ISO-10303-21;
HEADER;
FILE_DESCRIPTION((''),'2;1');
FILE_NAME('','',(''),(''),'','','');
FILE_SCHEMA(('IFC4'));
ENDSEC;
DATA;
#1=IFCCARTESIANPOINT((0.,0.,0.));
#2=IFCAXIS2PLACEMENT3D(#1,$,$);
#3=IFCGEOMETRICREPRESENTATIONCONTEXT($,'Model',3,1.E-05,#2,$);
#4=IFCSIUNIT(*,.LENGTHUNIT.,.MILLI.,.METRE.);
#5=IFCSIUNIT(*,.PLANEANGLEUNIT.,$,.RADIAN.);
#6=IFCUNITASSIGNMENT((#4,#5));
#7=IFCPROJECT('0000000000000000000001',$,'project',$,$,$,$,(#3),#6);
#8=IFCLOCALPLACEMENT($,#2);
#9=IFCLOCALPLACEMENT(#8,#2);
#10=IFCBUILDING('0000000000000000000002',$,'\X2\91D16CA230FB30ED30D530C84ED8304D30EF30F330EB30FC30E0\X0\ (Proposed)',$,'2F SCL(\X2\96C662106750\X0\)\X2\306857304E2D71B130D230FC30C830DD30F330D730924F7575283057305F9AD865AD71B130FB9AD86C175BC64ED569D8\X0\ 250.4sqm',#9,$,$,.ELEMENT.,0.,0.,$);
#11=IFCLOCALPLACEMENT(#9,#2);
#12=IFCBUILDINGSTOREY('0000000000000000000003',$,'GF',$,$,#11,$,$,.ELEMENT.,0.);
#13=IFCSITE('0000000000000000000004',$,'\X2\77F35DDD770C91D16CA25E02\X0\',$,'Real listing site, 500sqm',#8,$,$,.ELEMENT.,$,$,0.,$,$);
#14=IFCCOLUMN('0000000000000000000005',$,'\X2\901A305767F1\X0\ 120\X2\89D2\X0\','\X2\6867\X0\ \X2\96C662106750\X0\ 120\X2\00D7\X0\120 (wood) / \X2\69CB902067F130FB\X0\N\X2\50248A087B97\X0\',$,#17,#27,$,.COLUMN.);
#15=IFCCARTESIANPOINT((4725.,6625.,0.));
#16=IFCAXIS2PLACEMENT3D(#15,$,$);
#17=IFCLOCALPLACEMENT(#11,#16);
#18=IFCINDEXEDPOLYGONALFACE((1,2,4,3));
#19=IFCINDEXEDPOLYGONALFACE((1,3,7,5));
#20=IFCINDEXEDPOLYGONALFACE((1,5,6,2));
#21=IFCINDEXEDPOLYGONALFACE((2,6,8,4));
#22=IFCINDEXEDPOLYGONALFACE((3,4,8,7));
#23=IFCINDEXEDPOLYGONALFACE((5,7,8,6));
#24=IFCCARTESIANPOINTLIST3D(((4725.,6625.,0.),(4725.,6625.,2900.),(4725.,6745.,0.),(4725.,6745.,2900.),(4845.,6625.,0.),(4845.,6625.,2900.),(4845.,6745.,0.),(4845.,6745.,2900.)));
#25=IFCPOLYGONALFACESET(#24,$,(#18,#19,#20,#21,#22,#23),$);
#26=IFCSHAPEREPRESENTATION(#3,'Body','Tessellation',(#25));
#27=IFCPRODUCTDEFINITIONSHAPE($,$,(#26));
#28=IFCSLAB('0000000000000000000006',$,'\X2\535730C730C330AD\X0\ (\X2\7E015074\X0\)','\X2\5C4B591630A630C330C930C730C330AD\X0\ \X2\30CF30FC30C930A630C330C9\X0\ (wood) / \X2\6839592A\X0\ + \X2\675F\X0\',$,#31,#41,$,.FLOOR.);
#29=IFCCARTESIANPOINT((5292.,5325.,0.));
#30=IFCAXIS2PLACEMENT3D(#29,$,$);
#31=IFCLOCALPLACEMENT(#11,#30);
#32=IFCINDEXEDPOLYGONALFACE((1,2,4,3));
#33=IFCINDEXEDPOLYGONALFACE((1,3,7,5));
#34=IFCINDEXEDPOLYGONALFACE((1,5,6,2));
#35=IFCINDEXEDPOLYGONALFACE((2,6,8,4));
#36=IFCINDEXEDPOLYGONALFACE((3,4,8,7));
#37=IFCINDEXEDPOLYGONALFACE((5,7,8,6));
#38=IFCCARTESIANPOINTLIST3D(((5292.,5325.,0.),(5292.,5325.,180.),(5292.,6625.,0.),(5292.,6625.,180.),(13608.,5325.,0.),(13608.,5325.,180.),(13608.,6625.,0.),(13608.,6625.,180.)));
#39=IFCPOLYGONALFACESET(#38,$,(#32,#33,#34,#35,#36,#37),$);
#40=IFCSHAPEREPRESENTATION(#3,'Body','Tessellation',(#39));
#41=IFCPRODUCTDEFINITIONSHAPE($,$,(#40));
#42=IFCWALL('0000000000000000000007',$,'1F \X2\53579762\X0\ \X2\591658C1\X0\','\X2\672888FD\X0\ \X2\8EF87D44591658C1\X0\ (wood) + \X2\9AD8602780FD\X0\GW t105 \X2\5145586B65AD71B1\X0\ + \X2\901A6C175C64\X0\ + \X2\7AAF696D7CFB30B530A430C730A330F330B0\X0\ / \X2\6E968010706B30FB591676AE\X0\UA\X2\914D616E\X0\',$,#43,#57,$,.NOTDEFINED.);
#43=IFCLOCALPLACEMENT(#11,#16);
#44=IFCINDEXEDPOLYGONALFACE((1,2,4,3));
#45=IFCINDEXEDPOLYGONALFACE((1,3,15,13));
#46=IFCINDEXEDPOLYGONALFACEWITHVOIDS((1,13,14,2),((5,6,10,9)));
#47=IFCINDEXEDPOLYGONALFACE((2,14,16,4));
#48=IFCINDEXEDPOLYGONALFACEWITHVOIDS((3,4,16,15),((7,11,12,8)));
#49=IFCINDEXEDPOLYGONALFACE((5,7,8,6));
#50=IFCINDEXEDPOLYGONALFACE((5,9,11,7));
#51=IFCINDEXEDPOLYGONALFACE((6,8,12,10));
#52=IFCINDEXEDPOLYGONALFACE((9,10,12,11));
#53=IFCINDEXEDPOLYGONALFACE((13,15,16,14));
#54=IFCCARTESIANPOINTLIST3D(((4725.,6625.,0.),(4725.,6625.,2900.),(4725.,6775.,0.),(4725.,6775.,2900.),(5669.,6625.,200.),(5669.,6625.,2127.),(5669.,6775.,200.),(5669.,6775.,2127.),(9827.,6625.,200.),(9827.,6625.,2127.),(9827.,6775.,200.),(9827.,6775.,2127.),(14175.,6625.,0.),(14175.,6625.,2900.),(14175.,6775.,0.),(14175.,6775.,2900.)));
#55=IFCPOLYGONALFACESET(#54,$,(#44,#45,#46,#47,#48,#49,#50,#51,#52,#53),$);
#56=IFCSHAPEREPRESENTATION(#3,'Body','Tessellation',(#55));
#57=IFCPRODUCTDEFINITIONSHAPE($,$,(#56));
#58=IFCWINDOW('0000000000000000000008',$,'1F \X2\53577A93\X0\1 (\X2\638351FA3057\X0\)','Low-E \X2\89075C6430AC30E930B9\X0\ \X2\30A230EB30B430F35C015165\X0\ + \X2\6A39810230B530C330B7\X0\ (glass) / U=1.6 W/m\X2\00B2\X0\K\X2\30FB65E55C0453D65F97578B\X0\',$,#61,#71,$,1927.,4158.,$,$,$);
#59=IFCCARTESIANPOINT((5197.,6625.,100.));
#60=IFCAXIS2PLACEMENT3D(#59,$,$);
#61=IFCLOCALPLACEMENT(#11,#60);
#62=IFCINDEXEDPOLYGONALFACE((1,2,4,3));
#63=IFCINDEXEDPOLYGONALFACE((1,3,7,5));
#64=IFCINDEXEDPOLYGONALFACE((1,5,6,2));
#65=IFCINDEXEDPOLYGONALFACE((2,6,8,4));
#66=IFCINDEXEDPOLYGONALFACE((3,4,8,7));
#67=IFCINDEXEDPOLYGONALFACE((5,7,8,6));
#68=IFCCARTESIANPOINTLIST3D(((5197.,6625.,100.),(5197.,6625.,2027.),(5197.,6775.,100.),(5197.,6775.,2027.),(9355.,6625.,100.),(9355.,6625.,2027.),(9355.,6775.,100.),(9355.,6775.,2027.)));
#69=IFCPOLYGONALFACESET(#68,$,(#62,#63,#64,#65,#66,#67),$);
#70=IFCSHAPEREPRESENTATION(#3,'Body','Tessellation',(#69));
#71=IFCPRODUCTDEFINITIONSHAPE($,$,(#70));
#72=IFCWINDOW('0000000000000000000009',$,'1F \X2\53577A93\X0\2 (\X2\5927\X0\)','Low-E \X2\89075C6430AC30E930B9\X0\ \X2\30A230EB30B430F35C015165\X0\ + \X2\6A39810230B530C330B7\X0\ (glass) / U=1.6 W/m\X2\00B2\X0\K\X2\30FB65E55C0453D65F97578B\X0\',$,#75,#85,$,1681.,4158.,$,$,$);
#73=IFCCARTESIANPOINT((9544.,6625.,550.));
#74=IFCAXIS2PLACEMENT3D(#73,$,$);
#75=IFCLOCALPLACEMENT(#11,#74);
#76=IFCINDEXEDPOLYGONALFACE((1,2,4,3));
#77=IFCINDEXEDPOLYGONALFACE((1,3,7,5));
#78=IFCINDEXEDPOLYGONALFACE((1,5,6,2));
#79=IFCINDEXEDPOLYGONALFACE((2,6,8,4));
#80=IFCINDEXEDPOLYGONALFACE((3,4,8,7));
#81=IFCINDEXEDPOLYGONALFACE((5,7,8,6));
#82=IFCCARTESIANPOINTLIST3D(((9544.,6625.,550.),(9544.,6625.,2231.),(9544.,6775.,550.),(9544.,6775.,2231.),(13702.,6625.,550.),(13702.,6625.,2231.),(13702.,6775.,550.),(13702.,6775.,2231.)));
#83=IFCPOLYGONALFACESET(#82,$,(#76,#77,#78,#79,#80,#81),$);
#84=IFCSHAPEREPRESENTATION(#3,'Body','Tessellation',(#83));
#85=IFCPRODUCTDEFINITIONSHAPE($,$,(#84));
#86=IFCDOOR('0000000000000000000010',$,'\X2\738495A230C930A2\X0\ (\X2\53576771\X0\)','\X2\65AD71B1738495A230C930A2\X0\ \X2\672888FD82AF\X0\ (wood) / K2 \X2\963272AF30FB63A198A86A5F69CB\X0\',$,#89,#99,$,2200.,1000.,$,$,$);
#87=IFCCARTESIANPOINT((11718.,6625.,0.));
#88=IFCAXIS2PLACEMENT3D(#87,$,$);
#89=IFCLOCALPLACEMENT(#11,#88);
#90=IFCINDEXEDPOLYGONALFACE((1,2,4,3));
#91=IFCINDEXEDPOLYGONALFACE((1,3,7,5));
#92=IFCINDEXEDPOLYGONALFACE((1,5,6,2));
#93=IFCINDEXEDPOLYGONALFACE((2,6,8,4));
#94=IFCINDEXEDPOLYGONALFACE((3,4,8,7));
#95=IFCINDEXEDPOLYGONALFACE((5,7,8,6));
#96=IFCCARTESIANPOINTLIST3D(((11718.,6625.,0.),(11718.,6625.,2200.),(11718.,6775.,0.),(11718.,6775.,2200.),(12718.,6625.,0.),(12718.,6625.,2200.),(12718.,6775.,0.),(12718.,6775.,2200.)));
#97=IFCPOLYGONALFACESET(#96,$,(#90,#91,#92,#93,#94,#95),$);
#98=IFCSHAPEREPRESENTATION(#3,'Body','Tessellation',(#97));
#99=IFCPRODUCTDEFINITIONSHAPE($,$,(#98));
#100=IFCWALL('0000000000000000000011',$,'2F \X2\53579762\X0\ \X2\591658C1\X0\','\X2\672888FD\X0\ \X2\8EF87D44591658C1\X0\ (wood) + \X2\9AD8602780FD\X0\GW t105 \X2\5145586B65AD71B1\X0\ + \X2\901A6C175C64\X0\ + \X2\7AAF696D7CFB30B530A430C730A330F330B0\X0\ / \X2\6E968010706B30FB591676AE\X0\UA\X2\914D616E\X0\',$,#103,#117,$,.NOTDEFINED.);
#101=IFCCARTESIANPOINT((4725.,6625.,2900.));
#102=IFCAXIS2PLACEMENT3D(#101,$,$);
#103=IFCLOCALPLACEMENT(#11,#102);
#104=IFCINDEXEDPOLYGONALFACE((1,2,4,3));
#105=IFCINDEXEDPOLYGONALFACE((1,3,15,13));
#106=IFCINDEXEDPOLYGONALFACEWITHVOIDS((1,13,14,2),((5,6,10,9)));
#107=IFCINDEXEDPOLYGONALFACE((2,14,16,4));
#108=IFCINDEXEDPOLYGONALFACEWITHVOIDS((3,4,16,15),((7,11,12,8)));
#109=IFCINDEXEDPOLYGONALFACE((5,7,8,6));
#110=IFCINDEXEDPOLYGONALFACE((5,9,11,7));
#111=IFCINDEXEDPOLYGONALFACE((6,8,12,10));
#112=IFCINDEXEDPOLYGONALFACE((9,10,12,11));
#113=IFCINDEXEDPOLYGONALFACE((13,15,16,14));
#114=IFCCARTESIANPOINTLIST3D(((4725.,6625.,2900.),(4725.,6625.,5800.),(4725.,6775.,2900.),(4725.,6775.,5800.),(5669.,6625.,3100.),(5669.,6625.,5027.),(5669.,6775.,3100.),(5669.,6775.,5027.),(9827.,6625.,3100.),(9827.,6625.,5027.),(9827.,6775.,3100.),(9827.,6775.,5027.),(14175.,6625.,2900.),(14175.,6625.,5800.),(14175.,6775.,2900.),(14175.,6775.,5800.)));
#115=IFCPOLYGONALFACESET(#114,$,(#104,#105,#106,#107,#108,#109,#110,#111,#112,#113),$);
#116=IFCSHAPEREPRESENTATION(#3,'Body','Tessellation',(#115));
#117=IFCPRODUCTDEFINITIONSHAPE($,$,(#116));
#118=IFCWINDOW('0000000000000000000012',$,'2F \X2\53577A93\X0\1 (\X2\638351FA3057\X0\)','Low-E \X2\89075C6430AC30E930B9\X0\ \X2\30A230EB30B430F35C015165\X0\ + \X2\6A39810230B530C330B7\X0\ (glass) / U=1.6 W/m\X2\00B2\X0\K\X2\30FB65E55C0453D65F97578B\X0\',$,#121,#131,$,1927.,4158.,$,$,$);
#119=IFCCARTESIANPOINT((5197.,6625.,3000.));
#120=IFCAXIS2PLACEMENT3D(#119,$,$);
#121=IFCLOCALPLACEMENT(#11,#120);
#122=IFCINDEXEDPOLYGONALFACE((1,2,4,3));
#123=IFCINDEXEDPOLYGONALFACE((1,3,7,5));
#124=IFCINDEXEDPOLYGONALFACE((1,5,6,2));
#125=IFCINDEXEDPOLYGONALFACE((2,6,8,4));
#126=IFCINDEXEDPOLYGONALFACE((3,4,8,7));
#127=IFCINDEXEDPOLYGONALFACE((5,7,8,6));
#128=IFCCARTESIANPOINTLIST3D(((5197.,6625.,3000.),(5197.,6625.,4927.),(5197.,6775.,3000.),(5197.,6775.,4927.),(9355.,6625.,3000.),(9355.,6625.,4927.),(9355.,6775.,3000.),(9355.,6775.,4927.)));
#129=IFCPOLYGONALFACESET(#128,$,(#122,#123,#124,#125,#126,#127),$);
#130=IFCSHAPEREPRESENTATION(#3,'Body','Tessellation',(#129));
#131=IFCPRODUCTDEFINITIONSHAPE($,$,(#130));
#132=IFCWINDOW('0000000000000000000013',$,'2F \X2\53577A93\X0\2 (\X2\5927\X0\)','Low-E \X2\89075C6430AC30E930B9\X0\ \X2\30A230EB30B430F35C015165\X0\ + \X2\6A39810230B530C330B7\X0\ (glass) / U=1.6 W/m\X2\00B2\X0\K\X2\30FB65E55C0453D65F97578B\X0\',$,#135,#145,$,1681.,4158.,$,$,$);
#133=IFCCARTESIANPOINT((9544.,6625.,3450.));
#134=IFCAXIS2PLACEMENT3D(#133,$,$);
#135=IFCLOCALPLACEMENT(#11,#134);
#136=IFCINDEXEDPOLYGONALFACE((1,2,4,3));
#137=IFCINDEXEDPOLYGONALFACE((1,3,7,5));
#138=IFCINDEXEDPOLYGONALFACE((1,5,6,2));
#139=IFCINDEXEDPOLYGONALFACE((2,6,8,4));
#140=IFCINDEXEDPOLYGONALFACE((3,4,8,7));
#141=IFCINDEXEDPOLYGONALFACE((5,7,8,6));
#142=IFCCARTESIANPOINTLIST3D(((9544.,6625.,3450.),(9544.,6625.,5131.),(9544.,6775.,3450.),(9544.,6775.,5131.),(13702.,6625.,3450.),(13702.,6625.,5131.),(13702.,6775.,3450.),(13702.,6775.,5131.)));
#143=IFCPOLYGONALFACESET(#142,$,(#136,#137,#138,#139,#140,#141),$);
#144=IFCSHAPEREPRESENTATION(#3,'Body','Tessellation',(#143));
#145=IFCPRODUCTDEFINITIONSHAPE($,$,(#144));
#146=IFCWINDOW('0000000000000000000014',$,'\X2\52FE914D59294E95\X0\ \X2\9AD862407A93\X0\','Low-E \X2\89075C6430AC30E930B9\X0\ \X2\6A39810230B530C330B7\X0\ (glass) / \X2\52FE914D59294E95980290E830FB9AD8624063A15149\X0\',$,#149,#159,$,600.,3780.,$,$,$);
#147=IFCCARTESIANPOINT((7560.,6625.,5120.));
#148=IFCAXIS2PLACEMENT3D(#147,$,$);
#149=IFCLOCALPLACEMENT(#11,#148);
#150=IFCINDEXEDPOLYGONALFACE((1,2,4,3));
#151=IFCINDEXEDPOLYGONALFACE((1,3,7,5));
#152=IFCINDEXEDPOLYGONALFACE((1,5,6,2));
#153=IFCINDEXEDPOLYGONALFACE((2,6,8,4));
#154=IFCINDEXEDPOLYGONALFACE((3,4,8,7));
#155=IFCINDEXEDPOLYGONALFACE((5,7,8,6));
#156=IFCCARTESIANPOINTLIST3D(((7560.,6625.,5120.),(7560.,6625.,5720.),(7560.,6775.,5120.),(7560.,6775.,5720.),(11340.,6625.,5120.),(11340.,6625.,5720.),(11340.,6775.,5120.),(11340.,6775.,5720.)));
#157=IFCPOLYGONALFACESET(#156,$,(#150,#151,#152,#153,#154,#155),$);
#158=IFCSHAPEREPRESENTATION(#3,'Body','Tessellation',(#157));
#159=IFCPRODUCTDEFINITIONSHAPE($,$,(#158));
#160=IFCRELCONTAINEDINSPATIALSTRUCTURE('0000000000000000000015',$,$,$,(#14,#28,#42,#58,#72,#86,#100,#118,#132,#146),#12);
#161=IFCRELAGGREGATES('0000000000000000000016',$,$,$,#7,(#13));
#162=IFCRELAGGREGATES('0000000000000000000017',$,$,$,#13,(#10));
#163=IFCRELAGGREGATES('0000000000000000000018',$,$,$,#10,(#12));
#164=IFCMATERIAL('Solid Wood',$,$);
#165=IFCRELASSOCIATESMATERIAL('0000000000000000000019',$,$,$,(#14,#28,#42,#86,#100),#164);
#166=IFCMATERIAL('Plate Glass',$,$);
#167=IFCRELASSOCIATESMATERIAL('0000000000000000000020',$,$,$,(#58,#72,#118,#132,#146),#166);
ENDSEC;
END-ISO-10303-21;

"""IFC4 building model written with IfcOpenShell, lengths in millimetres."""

from ifc_helpers import new_model, si_unit, frame, frame_2d, origin, place, context, project, spatial, rectangle, extrude, material, element, fill, save


model = new_model("IFC4")

# Units and contexts
model_context = context("Model", 3, precision=1e-05, world=origin())
ifc_project = project(units=[si_unit("LENGTHUNIT", "METRE", prefix="MILLI"), si_unit("PLANEANGLEUNIT", "RADIAN")], contexts=[model_context])

# Site, building, storey
site_placement = place(None, origin())
site = spatial("IfcSite", under=ifc_project, at=site_placement, Name="石川県金沢市", ObjectType="Real listing site, 500sqm", CompositionType="ELEMENT", RefElevation=0.0)
building_placement = place(site_placement, origin())
building = spatial("IfcBuilding", under=site, at=building_placement, Name="金沢・ロフト付きワンルーム (Proposed)", ObjectType="2F SCL(集成材)と地中熱ヒートポンプを併用した高断熱・高気密仕様 250.4sqm", CompositionType="ELEMENT", ElevationOfRefHeight=0.0, ElevationOfTerrain=0.0)
storey_placement = place(building_placement, origin())
storey = spatial("IfcBuildingStorey", under=building, at=storey_placement, Name="GF", CompositionType="ELEMENT", Elevation=0.0)

# Column
ifc_material_1 = material(Name="Solid Wood")
column_placement = place(storey_placement, frame((4725.0, 6625.0, 0.0)))
element("IfcColumn", 1, at=column_placement, inside=storey, material=ifc_material_1, Name="通し柱 120角", Description="桧 集成材 120×120 (wood) / 構造柱・N値計算", PredefinedType="COLUMN", context=model_context, shape_type="SweptSolid", body=[
    extrude(rectangle(XDim=120.0, YDim=120.0, at=frame_2d((60.0, 60.0))), frame((4725.0, 6625.0, 0.0)), (0.0, 0.0, 1.0), 2900.0),
])

# Slab
slab_1_placement = place(storey_placement, frame((5292.0, 5325.0, 0.0)))
element("IfcSlab", 2, at=slab_1_placement, inside=storey, material=ifc_material_1, Name="南デッキ (縁側)", Description="屋外ウッドデッキ ハードウッド (wood) / 根太 + 束", PredefinedType="FLOOR", context=model_context, shape_type="SweptSolid", body=[
    extrude(rectangle(XDim=8316.0, YDim=1300.0, at=frame_2d((4158.0, 650.0))), frame((5292.0, 5325.0, 0.0)), (0.0, 0.0, 1.0), 180.0),
])

# Wall, openings, windows, door
wall_1_placement = place(storey_placement, frame((4725.0, 6625.0, 0.0)))
wall_1 = element("IfcWall", 3, at=wall_1_placement, inside=storey, material=ifc_material_1, Name="1F 南面 外壁", Description="木製 軸組外壁 (wood) + 高性能GW t105 充填断熱 + 通気層 + 窯業系サイディング / 準耐火・外皮UA配慮", PredefinedType="NOTDEFINED", context=model_context, shape_type="SweptSolid", body=[
    extrude(rectangle(XDim=9450.0, YDim=150.0, at=frame_2d((4725.0, 75.0))), frame((4725.0, 6625.0, 0.0)), (0.0, 0.0, 1.0), 2900.0),
])
opening_1_placement = place(storey_placement, frame((5197.0, 6625.0, 100.0)))
opening_1 = element("IfcOpeningElement", 4, at=opening_1_placement, cuts=wall_1, PredefinedType="NOTDEFINED", context=model_context, shape_type="SweptSolid", body=[
    extrude(rectangle(XDim=4158.0, YDim=150.0, at=frame_2d((2079.0, 75.0))), frame((5197.0, 6625.0, 100.0)), (0.0, 0.0, 1.0), 1927.0),
])
opening_2_placement = place(storey_placement, frame((9544.0, 6625.0, 550.0)))
opening_2 = element("IfcOpeningElement", 5, at=opening_2_placement, cuts=wall_1, PredefinedType="NOTDEFINED", context=model_context, shape_type="SweptSolid", body=[
    extrude(rectangle(XDim=4158.0, YDim=150.0, at=frame_2d((2079.0, 75.0))), frame((9544.0, 6625.0, 550.0)), (0.0, 0.0, 1.0), 1681.0),
])
opening_3_placement = place(storey_placement, frame((11718.0, 6625.0, 0.0)))
opening_3 = element("IfcOpeningElement", 6, at=opening_3_placement, cuts=wall_1, PredefinedType="NOTDEFINED", context=model_context, shape_type="SweptSolid", body=[
    extrude(rectangle(XDim=1000.0, YDim=150.0, at=frame_2d((500.0, 75.0))), frame((11718.0, 6625.0, 0.0)), (0.0, 0.0, 1.0), 2200.0),
])
ifc_material_2 = material(Name="Plate Glass")
window_1_placement = place(storey_placement, frame((5197.0, 6625.0, 100.0)))
window_1 = element("IfcWindow", 7, at=window_1_placement, inside=storey, material=ifc_material_2, Name="1F 南窓1 (掃出し)", Description="Low-E 複層ガラス アルゴン封入 + 樹脂サッシ (glass) / U=1.6 W/m²K・日射取得型", OverallHeight=1927.0, OverallWidth=4158.0, context=model_context, shape_type="SweptSolid", body=[
    extrude(rectangle(XDim=4158.0, YDim=150.0, at=frame_2d((2079.0, 75.0))), frame((5197.0, 6625.0, 100.0)), (0.0, 0.0, 1.0), 1927.0),
])
fill(opening_1, window_1)
window_2_placement = place(storey_placement, frame((9544.0, 6625.0, 550.0)))
window_2 = element("IfcWindow", 8, at=window_2_placement, inside=storey, material=ifc_material_2, Name="1F 南窓2 (大)", Description="Low-E 複層ガラス アルゴン封入 + 樹脂サッシ (glass) / U=1.6 W/m²K・日射取得型", OverallHeight=1681.0, OverallWidth=4158.0, context=model_context, shape_type="SweptSolid", body=[
    extrude(rectangle(XDim=4158.0, YDim=150.0, at=frame_2d((2079.0, 75.0))), frame((9544.0, 6625.0, 550.0)), (0.0, 0.0, 1.0), 1681.0),
])
fill(opening_2, window_2)
door_placement = place(storey_placement, frame((11718.0, 6625.0, 0.0)))
door = element("IfcDoor", 9, at=door_placement, inside=storey, material=ifc_material_1, Name="玄関ドア (南東)", Description="断熱玄関ドア 木製芯 (wood) / K2 防犯・採風機構", OverallHeight=2200.0, OverallWidth=1000.0, context=model_context, shape_type="SweptSolid", body=[
    extrude(rectangle(XDim=1000.0, YDim=150.0, at=frame_2d((500.0, 75.0))), frame((11718.0, 6625.0, 0.0)), (0.0, 0.0, 1.0), 2200.0),
])
fill(opening_3, door)

# Wall, openings, windows
wall_2_placement = place(storey_placement, frame((4725.0, 6625.0, 2900.0)))
wall_2 = element("IfcWall", 10, at=wall_2_placement, inside=storey, material=ifc_material_1, Name="2F 南面 外壁", Description="木製 軸組外壁 (wood) + 高性能GW t105 充填断熱 + 通気層 + 窯業系サイディング / 準耐火・外皮UA配慮", PredefinedType="NOTDEFINED", context=model_context, shape_type="SweptSolid", body=[
    extrude(rectangle(XDim=9450.0, YDim=150.0, at=frame_2d((4725.0, 75.0))), frame((4725.0, 6625.0, 2900.0)), (0.0, 0.0, 1.0), 2900.0),
])
opening_4_placement = place(storey_placement, frame((5197.0, 6625.0, 3000.0)))
opening_4 = element("IfcOpeningElement", 11, at=opening_4_placement, cuts=wall_2, PredefinedType="NOTDEFINED", context=model_context, shape_type="SweptSolid", body=[
    extrude(rectangle(XDim=4158.0, YDim=150.0, at=frame_2d((2079.0, 75.0))), frame((5197.0, 6625.0, 3000.0)), (0.0, 0.0, 1.0), 1927.0),
])
opening_5_placement = place(storey_placement, frame((9544.0, 6625.0, 3450.0)))
opening_5 = element("IfcOpeningElement", 12, at=opening_5_placement, cuts=wall_2, PredefinedType="NOTDEFINED", context=model_context, shape_type="SweptSolid", body=[
    extrude(rectangle(XDim=4158.0, YDim=150.0, at=frame_2d((2079.0, 75.0))), frame((9544.0, 6625.0, 3450.0)), (0.0, 0.0, 1.0), 1681.0),
])
opening_6_placement = place(storey_placement, frame((7560.0, 6625.0, 5120.0)))
opening_6 = element("IfcOpeningElement", 13, at=opening_6_placement, cuts=wall_2, PredefinedType="NOTDEFINED", context=model_context, shape_type="SweptSolid", body=[
    extrude(rectangle(XDim=3780.0, YDim=150.0, at=frame_2d((1890.0, 75.0))), frame((7560.0, 6625.0, 5120.0)), (0.0, 0.0, 1.0), 600.0),
])
window_3_placement = place(storey_placement, frame((5197.0, 6625.0, 3000.0)))
window_3 = element("IfcWindow", 14, at=window_3_placement, inside=storey, material=ifc_material_2, Name="2F 南窓1 (掃出し)", Description="Low-E 複層ガラス アルゴン封入 + 樹脂サッシ (glass) / U=1.6 W/m²K・日射取得型", OverallHeight=1927.0, OverallWidth=4158.0, context=model_context, shape_type="SweptSolid", body=[
    extrude(rectangle(XDim=4158.0, YDim=150.0, at=frame_2d((2079.0, 75.0))), frame((5197.0, 6625.0, 3000.0)), (0.0, 0.0, 1.0), 1927.0),
])
fill(opening_4, window_3)
window_4_placement = place(storey_placement, frame((9544.0, 6625.0, 3450.0)))
window_4 = element("IfcWindow", 15, at=window_4_placement, inside=storey, material=ifc_material_2, Name="2F 南窓2 (大)", Description="Low-E 複層ガラス アルゴン封入 + 樹脂サッシ (glass) / U=1.6 W/m²K・日射取得型", OverallHeight=1681.0, OverallWidth=4158.0, context=model_context, shape_type="SweptSolid", body=[
    extrude(rectangle(XDim=4158.0, YDim=150.0, at=frame_2d((2079.0, 75.0))), frame((9544.0, 6625.0, 3450.0)), (0.0, 0.0, 1.0), 1681.0),
])
fill(opening_5, window_4)
window_5_placement = place(storey_placement, frame((7560.0, 6625.0, 5120.0)))
window_5 = element("IfcWindow", 16, at=window_5_placement, inside=storey, material=ifc_material_2, Name="勾配天井 高所窓", Description="Low-E 複層ガラス 樹脂サッシ (glass) / 勾配天井頂部・高所採光", OverallHeight=600.0, OverallWidth=3780.0, context=model_context, shape_type="SweptSolid", body=[
    extrude(rectangle(XDim=3780.0, YDim=150.0, at=frame_2d((1890.0, 75.0))), frame((7560.0, 6625.0, 5120.0)), (0.0, 0.0, 1.0), 600.0),
])
fill(opening_6, window_5)

save(model, "model.ifc")
